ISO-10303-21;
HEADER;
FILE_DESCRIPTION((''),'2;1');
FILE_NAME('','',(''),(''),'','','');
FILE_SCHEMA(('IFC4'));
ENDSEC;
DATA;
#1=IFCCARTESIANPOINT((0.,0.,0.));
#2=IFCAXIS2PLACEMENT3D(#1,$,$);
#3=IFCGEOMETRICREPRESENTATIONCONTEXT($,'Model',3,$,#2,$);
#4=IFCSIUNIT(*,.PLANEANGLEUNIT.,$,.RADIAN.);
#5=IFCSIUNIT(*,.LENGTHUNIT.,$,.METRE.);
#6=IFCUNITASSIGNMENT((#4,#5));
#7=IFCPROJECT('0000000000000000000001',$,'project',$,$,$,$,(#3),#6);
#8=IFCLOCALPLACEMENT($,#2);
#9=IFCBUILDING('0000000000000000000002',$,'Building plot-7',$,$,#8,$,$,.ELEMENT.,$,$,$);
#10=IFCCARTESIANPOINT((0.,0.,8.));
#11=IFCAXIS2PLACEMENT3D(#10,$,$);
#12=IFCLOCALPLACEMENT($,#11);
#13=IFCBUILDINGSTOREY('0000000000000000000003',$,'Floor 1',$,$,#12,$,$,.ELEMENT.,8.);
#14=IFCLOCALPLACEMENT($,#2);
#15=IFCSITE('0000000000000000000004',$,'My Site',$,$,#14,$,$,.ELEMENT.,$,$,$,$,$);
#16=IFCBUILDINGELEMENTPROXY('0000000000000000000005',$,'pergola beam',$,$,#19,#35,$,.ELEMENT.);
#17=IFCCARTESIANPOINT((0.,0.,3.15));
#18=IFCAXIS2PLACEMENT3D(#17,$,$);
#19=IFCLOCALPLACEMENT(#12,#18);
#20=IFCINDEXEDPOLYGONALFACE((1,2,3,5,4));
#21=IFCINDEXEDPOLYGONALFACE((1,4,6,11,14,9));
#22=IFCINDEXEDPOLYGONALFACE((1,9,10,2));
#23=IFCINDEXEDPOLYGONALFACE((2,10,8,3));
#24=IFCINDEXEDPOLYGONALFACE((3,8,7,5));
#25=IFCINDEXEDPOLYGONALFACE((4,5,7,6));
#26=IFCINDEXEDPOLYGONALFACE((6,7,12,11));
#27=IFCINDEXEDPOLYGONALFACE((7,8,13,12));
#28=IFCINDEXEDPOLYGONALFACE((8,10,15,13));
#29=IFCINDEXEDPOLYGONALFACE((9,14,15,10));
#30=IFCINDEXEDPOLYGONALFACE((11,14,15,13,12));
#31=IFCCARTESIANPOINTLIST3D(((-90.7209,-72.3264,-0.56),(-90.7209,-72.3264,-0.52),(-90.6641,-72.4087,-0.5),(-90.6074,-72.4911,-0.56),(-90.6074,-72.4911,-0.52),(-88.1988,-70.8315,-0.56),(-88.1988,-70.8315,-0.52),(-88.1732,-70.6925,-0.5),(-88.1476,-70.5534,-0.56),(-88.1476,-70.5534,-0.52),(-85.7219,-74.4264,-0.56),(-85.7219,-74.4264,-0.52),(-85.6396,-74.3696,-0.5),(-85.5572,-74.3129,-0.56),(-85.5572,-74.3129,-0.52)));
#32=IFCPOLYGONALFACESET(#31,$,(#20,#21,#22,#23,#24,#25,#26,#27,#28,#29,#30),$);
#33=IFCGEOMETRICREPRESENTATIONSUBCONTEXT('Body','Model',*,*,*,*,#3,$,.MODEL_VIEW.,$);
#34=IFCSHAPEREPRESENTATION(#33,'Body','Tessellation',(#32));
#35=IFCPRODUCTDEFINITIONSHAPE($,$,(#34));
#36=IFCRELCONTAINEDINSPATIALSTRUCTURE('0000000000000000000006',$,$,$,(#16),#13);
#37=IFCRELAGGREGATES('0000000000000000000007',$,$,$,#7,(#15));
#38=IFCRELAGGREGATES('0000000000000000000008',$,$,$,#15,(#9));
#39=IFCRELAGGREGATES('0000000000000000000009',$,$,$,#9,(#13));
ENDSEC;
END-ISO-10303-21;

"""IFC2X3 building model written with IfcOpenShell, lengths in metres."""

from ifc_helpers import new_model, entity, si_unit, frame, origin, place, context, subcontext, project, spatial, element, save


model = new_model("IFC2X3")

# Units and contexts
model_context = context("Model", 3, world=origin())
body_context = subcontext(model_context, "Body", "Model", "MODEL_VIEW")
ifc_project = project(units=[si_unit("PLANEANGLEUNIT", "RADIAN"), si_unit("LENGTHUNIT", "METRE")], contexts=[model_context])

# Site, building, storey
site_placement = place(None, origin())
site = spatial("IfcSite", under=ifc_project, at=site_placement, Name="My Site", CompositionType="ELEMENT")
building_placement = place(None, origin())
building = spatial("IfcBuilding", under=site, at=building_placement, Name="Building plot-7", CompositionType="ELEMENT")
storey_placement = place(None, frame((0.0, 0.0, 8.0)))
storey = spatial("IfcBuildingStorey", under=building, at=storey_placement, Name="Floor 1", CompositionType="ELEMENT", Elevation=8.0)

# Building element proxy
proxy_1_placement = place(storey_placement, frame((0.0, 0.0, 3.15)))
axis2_placement3_d_1 = entity("IfcAxis2Placement3D", entity("IfcCartesianPoint", [0.0, 0.0, 0.0]))
element("IfcBuildingElementProxy", 1, at=proxy_1_placement, inside=storey, Name="pergola beam", CompositionType="ELEMENT", context=body_context, shape_type="SweptSolid", held_by="IfcProductRepresentation", body=[
    entity("IfcSurfaceCurveSweptAreaSolid", entity("IfcArbitraryClosedProfileDef", "AREA", None, entity("IfcPolyline", [entity("IfcCartesianPoint", [-0.5, 0.0]), entity("IfcCartesianPoint", [-0.52, -0.1]), entity("IfcCartesianPoint", [-0.56, -0.1]), entity("IfcCartesianPoint", [-0.56, 0.1]), entity("IfcCartesianPoint", [-0.52, 0.1]), entity("IfcCartesianPoint", [-0.5, 0.0])])), axis2_placement3_d_1, entity("IfcPolyline", [entity("IfcCartesianPoint", [90.6855, 69.712]), entity("IfcCartesianPoint", [88.1519, 73.3892]), entity("IfcCartesianPoint", [85.6609, 71.6729])]), 0.0, 1.0, entity("IfcPlane", axis2_placement3_d_1)),
])

save(model, "model.ifc")
